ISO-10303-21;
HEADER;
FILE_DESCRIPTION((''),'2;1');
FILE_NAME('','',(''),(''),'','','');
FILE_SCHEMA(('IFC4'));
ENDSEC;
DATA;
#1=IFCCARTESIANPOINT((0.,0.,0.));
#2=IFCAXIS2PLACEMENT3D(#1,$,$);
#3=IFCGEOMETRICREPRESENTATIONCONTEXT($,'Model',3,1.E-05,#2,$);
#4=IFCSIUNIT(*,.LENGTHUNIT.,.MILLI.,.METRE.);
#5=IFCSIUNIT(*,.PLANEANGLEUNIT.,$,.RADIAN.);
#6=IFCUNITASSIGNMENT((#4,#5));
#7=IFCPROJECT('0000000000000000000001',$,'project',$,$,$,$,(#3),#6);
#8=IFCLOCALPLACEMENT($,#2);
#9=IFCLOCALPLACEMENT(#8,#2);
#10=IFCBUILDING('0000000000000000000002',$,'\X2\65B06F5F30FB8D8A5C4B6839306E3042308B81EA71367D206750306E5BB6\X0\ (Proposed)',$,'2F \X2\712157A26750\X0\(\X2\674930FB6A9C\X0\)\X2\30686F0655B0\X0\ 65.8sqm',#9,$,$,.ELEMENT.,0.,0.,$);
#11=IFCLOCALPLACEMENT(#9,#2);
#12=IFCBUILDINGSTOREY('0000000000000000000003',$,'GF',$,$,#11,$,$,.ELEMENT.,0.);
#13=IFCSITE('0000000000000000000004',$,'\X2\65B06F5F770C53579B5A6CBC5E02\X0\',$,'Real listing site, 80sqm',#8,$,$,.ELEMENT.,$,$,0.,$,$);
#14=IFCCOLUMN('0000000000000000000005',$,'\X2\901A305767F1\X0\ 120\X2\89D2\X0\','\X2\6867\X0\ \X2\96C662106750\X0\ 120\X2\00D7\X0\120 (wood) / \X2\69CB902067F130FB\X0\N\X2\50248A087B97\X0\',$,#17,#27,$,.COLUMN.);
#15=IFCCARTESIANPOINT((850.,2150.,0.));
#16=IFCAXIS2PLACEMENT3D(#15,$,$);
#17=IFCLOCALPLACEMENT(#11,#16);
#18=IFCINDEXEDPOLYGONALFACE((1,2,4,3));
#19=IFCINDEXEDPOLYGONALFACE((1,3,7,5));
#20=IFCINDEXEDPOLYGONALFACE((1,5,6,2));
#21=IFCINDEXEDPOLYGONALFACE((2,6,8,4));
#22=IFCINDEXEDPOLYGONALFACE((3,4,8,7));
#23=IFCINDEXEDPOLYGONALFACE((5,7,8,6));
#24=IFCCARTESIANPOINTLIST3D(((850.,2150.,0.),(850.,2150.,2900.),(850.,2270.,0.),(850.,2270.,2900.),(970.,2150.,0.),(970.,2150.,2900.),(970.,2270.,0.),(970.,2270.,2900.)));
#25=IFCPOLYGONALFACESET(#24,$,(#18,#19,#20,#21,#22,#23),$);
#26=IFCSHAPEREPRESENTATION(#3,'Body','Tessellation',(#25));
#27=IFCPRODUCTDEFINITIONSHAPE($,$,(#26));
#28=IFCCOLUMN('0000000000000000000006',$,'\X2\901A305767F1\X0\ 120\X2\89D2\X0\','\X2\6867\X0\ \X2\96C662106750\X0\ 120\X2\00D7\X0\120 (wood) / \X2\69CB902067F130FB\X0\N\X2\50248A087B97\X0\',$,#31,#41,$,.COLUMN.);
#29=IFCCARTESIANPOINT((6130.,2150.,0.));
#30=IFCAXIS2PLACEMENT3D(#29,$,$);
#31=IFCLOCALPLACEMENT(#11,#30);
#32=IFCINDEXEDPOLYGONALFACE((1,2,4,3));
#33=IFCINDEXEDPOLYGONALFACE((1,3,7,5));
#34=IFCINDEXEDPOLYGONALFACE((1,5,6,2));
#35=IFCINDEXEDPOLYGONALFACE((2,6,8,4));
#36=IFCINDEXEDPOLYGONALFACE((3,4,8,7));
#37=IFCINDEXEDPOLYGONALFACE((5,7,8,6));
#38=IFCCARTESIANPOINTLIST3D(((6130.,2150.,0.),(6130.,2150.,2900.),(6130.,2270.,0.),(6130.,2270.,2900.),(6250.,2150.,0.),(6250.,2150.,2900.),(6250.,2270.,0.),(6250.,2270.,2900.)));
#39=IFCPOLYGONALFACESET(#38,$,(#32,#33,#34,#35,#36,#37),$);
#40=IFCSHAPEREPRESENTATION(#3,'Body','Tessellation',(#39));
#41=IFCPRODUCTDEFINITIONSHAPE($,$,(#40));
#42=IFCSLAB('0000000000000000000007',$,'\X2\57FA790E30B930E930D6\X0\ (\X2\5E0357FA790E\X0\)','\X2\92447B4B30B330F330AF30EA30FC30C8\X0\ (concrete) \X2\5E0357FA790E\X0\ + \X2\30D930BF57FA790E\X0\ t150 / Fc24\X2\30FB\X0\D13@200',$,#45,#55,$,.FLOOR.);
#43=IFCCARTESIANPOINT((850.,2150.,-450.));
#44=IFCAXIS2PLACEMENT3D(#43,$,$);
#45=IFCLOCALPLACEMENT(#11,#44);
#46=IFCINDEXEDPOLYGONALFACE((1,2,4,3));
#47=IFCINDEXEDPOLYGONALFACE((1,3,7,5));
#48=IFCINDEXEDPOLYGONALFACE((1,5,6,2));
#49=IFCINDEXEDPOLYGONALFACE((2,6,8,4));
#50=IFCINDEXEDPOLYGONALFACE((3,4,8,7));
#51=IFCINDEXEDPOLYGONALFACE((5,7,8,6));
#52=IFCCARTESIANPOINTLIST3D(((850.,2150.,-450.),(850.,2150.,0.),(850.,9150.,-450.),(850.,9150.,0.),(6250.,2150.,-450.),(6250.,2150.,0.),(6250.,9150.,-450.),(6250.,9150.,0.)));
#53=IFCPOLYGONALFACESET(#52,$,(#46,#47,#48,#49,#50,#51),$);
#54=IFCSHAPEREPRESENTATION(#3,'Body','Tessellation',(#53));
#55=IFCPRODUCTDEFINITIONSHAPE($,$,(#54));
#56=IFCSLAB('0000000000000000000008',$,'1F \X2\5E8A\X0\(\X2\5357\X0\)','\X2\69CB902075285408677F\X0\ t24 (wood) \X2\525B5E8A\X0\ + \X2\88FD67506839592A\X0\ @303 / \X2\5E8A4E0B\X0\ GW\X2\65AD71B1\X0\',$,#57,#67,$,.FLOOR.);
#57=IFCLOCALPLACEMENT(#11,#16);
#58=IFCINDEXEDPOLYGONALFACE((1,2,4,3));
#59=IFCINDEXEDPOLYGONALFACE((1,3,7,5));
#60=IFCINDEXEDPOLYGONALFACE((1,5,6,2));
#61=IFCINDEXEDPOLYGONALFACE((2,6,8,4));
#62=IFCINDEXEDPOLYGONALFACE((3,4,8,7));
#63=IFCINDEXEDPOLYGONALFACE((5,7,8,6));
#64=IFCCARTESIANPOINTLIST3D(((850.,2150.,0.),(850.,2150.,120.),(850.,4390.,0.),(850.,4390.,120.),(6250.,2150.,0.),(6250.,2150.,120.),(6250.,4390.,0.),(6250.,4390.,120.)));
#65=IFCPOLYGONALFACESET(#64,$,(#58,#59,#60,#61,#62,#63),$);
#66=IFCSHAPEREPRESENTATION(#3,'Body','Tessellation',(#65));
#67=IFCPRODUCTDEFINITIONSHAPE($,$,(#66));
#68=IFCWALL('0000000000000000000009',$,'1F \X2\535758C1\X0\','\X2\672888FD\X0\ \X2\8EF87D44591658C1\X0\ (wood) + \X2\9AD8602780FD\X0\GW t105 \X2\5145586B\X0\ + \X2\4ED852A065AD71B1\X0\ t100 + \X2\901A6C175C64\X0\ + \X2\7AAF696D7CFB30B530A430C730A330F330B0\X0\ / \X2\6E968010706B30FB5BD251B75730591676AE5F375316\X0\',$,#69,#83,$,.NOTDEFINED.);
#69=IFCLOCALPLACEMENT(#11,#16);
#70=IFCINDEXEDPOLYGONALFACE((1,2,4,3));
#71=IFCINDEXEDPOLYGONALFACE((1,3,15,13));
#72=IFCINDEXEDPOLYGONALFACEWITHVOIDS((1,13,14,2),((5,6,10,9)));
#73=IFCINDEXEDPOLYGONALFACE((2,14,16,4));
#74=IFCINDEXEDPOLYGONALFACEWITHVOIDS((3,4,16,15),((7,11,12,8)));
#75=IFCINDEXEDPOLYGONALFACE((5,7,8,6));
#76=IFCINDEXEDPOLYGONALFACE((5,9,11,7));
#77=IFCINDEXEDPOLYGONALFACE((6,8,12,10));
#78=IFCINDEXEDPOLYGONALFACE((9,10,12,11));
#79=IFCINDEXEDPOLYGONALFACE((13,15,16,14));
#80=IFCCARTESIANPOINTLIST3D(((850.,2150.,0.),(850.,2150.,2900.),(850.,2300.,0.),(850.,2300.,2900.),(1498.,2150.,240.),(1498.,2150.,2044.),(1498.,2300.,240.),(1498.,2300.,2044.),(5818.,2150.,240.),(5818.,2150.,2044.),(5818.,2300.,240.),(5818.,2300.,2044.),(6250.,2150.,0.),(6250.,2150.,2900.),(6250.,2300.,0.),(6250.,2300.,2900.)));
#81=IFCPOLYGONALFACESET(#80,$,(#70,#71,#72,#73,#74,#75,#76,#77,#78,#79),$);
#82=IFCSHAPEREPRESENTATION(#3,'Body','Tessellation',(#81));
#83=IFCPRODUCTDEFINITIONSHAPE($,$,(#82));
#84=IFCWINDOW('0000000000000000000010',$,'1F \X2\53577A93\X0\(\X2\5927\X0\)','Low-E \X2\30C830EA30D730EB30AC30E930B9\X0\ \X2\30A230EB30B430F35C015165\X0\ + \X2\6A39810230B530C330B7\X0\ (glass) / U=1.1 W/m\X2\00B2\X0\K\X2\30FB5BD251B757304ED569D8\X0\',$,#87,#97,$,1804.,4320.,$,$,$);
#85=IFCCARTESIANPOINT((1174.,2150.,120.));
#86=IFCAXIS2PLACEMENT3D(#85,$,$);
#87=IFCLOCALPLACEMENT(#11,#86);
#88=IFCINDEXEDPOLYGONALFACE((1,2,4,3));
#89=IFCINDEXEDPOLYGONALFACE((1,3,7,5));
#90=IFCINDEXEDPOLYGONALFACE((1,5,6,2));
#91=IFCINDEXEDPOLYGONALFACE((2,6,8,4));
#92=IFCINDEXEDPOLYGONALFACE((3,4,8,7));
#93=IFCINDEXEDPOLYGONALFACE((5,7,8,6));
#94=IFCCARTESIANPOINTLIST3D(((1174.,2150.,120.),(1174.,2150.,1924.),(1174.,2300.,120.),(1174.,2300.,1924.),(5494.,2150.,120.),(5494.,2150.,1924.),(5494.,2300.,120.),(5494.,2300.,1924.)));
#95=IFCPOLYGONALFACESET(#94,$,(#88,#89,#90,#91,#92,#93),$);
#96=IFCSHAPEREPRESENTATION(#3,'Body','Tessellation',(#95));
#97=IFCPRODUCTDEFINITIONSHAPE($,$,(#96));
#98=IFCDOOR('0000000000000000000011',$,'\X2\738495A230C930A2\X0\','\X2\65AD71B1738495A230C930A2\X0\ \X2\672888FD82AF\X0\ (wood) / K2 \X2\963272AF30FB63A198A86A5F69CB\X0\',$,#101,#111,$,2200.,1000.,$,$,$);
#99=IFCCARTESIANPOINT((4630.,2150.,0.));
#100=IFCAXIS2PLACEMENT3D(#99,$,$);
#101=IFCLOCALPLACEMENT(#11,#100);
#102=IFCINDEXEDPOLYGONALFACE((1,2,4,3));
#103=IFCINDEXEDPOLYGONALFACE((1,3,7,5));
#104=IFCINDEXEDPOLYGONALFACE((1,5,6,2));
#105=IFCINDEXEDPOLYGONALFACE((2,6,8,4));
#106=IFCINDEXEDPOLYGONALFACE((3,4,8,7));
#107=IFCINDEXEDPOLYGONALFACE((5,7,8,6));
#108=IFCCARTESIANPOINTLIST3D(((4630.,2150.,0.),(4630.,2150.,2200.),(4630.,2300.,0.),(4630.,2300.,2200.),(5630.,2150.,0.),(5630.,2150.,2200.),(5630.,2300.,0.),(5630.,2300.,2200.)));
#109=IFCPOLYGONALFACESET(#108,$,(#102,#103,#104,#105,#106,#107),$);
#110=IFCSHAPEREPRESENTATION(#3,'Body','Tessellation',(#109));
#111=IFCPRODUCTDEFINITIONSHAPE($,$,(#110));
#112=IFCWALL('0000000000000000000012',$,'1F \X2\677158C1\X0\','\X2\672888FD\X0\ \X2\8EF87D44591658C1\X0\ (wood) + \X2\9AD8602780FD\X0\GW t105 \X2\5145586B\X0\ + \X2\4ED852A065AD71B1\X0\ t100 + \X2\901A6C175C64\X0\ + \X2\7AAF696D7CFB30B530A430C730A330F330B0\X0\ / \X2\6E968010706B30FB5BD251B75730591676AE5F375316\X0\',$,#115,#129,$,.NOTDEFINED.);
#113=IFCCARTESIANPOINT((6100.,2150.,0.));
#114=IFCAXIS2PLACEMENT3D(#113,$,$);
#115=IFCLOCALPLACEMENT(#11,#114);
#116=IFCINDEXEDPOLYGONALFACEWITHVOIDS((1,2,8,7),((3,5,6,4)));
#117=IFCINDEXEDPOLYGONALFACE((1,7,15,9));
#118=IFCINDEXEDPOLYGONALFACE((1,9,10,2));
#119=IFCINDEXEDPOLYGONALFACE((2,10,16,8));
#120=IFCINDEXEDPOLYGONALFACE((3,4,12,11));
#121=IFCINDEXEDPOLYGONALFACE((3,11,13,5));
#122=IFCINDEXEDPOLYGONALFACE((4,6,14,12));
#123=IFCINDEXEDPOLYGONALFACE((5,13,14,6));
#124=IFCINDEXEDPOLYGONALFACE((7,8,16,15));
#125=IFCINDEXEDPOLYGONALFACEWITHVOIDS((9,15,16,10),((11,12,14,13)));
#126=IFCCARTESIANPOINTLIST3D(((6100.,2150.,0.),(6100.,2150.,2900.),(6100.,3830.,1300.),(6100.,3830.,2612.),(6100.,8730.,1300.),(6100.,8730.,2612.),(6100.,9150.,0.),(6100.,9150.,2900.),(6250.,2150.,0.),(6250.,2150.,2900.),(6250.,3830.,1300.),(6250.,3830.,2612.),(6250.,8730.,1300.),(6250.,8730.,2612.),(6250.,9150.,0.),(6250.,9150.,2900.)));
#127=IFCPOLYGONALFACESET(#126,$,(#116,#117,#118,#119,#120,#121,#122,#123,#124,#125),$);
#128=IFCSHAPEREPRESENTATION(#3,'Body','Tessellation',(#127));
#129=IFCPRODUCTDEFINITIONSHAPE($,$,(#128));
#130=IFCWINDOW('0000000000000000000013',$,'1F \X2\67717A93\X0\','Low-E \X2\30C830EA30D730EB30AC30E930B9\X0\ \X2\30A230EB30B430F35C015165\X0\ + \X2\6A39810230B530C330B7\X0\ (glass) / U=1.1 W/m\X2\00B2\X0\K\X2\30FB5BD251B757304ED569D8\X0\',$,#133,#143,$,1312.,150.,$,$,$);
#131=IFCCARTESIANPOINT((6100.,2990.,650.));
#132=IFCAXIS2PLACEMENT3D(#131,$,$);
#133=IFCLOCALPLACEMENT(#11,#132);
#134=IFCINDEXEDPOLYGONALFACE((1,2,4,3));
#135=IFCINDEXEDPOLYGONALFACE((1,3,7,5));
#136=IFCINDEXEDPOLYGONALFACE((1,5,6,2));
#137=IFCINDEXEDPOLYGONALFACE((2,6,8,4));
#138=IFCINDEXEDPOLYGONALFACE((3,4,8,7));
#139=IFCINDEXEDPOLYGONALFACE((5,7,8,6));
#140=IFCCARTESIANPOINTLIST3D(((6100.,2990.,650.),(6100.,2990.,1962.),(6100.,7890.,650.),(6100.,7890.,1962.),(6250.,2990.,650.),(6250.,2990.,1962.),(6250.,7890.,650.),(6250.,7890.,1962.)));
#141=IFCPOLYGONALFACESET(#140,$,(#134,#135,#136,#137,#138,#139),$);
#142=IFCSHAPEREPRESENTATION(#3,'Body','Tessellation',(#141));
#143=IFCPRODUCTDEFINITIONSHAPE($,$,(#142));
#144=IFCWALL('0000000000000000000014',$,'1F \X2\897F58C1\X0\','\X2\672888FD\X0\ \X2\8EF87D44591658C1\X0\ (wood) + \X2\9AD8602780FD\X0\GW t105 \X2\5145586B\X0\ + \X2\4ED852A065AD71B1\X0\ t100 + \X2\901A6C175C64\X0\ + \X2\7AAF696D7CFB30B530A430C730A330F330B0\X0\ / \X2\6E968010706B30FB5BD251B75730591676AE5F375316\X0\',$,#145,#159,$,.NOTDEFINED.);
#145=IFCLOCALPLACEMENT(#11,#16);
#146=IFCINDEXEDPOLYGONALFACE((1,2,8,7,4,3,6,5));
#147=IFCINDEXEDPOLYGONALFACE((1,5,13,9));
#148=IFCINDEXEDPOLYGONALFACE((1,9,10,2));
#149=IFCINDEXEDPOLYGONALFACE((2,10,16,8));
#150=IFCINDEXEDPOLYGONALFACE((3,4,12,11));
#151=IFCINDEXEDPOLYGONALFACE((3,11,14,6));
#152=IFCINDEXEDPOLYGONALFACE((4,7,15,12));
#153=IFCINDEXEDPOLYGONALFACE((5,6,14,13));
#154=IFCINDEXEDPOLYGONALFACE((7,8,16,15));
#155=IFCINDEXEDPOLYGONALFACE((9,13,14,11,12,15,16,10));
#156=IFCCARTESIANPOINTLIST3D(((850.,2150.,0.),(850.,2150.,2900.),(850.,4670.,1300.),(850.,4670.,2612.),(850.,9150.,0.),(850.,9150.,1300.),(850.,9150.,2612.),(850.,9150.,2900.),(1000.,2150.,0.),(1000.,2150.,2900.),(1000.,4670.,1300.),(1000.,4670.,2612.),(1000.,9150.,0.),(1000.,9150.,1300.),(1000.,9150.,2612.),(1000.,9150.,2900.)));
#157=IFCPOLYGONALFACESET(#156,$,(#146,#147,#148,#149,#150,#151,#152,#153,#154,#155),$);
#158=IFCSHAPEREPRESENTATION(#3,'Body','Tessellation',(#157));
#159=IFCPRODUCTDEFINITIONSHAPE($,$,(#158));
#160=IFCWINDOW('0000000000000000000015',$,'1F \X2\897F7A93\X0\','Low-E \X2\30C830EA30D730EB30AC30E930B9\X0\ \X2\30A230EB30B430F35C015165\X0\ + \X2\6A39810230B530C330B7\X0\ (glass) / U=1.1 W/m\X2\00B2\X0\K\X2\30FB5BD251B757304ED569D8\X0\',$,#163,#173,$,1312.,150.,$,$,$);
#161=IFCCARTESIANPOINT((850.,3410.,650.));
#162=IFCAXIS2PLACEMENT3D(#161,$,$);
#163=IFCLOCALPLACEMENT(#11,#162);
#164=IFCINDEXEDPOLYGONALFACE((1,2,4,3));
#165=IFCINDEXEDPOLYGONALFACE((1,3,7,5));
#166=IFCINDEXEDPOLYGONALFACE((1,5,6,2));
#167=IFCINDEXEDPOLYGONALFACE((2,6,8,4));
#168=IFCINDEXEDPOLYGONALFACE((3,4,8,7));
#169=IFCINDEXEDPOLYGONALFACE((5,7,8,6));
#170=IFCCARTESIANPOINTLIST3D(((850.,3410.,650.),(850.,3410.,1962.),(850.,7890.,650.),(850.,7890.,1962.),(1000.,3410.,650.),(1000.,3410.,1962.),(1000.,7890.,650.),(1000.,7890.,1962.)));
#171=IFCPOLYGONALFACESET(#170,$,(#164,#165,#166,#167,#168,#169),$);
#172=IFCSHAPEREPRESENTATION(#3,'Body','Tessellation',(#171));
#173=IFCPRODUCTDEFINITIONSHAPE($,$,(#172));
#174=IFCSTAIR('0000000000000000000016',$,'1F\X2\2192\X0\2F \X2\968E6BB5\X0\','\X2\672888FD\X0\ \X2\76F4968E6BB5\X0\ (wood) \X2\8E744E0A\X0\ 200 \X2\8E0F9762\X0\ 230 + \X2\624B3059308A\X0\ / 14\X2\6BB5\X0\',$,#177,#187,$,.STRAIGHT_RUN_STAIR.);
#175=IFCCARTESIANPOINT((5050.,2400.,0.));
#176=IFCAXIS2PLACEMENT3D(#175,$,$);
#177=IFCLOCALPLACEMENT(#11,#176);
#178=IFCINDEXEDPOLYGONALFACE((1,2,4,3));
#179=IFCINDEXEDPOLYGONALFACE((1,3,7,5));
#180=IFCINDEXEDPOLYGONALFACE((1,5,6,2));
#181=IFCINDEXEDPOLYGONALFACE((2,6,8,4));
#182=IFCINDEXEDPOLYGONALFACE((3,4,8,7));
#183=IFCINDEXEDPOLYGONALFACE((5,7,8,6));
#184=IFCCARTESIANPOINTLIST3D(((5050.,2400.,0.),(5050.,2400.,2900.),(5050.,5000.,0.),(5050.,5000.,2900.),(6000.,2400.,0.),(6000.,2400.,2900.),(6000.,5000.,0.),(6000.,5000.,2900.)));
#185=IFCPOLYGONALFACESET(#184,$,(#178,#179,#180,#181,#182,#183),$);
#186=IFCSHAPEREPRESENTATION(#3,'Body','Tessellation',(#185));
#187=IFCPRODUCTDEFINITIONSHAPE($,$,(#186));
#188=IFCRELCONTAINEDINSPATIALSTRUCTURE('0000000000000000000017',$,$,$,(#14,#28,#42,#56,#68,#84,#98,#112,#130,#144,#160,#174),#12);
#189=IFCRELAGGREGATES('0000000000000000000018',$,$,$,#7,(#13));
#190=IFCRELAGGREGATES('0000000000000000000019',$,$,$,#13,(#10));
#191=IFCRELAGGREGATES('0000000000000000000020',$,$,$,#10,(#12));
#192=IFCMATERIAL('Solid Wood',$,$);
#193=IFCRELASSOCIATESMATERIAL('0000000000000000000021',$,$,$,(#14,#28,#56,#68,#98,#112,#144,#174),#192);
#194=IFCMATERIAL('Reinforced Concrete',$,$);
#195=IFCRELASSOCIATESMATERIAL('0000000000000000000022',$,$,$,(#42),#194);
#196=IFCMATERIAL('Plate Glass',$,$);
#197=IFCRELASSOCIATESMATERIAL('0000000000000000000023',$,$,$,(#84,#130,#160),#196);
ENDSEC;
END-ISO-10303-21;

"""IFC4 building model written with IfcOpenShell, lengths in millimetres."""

from ifc_helpers import new_model, si_unit, frame, frame_2d, origin, place, context, project, spatial, rectangle, extrude, material, element, fill, save


model = new_model("IFC4")

# Units and contexts
model_context = context("Model", 3, precision=1e-05, world=origin())
ifc_project = project(units=[si_unit("LENGTHUNIT", "METRE", prefix="MILLI"), si_unit("PLANEANGLEUNIT", "RADIAN")], contexts=[model_context])

# Site, building, storey
site_placement = place(None, origin())
site = spatial("IfcSite", under=ifc_project, at=site_placement, Name="新潟県南魚沼市", ObjectType="Real listing site, 80sqm", CompositionType="ELEMENT", RefElevation=0.0)
building_placement = place(site_placement, origin())
building = spatial("IfcBuilding", under=site, at=building_placement, Name="新潟・越屋根のある自然素材の家 (Proposed)", ObjectType="2F 無垢材(杉・檜)と漆喰 65.8sqm", CompositionType="ELEMENT", ElevationOfRefHeight=0.0, ElevationOfTerrain=0.0)
storey_placement = place(building_placement, origin())
storey = spatial("IfcBuildingStorey", under=building, at=storey_placement, Name="GF", CompositionType="ELEMENT", Elevation=0.0)

# Columns
ifc_material_1 = material(Name="Solid Wood")
column_1_placement = place(storey_placement, frame((850.0, 2150.0, 0.0)))
element("IfcColumn", 1, at=column_1_placement, inside=storey, material=ifc_material_1, Name="通し柱 120角", Description="桧 集成材 120×120 (wood) / 構造柱・N値計算", PredefinedType="COLUMN", context=model_context, shape_type="SweptSolid", body=[
    extrude(rectangle(XDim=120.0, YDim=120.0, at=frame_2d((60.0, 60.0))), frame((850.0, 2150.0, 0.0)), (0.0, 0.0, 1.0), 2900.0),
])
column_2_placement = place(storey_placement, frame((6130.0, 2150.0, 0.0)))
element("IfcColumn", 2, at=column_2_placement, inside=storey, material=ifc_material_1, Name="通し柱 120角", Description="桧 集成材 120×120 (wood) / 構造柱・N値計算", PredefinedType="COLUMN", context=model_context, shape_type="SweptSolid", body=[
    extrude(rectangle(XDim=120.0, YDim=120.0, at=frame_2d((60.0, 60.0))), frame((6130.0, 2150.0, 0.0)), (0.0, 0.0, 1.0), 2900.0),
])

# Slabs
ifc_material_2 = material(Name="Reinforced Concrete")
slab_1_placement = place(storey_placement, frame((850.0, 2150.0, -450.0)))
element("IfcSlab", 3, at=slab_1_placement, inside=storey, material=ifc_material_2, Name="基礎スラブ (布基礎)", Description="鉄筋コンクリート (concrete) 布基礎 + ベタ基礎 t150 / Fc24・D13@200", PredefinedType="FLOOR", context=model_context, shape_type="SweptSolid", body=[
    extrude(rectangle(XDim=5400.0, YDim=7000.0, at=frame_2d((2700.0, 3500.0))), frame((850.0, 2150.0, -450.0)), (0.0, 0.0, 1.0), 450.0),
])
slab_2_placement = place(storey_placement, frame((850.0, 2150.0, 0.0)))
element("IfcSlab", 4, at=slab_2_placement, inside=storey, material=ifc_material_1, Name="1F 床(南)", Description="構造用合板 t24 (wood) 剛床 + 製材根太 @303 / 床下 GW断熱", PredefinedType="FLOOR", context=model_context, shape_type="SweptSolid", body=[
    extrude(rectangle(XDim=5400.0, YDim=2240.0, at=frame_2d((2700.0, 1120.0))), frame((850.0, 2150.0, 0.0)), (0.0, 0.0, 1.0), 120.0),
])

# Wall, openings, window, door
wall_1_placement = place(storey_placement, frame((850.0, 2150.0, 0.0)))
wall_1 = element("IfcWall", 5, at=wall_1_placement, inside=storey, material=ifc_material_1, Name="1F 南壁", Description="木製 軸組外壁 (wood) + 高性能GW t105 充填 + 付加断熱 t100 + 通気層 + 窯業系サイディング / 準耐火・寒冷地外皮強化", PredefinedType="NOTDEFINED", context=model_context, shape_type="SweptSolid", body=[
    extrude(rectangle(XDim=5400.0, YDim=150.0, at=frame_2d((2700.0, 75.0))), frame((850.0, 2150.0, 0.0)), (0.0, 0.0, 1.0), 2900.0),
])
opening_1_placement = place(storey_placement, frame((1174.0, 2150.0, 120.0)))
opening_1 = element("IfcOpeningElement", 6, at=opening_1_placement, cuts=wall_1, PredefinedType="NOTDEFINED", context=model_context, shape_type="SweptSolid", body=[
    extrude(rectangle(XDim=4320.0, YDim=150.0, at=frame_2d((2160.0, 75.0))), frame((1174.0, 2150.0, 120.0)), (0.0, 0.0, 1.0), 1804.0),
])
opening_2_placement = place(storey_placement, frame((4630.0, 2150.0, 0.0)))
opening_2 = element("IfcOpeningElement", 7, at=opening_2_placement, cuts=wall_1, PredefinedType="NOTDEFINED", context=model_context, shape_type="SweptSolid", body=[
    extrude(rectangle(XDim=1000.0, YDim=150.0, at=frame_2d((500.0, 75.0))), frame((4630.0, 2150.0, 0.0)), (0.0, 0.0, 1.0), 2200.0),
])
ifc_material_3 = material(Name="Plate Glass")
window_1_placement = place(storey_placement, frame((1174.0, 2150.0, 120.0)))
window_1 = element("IfcWindow", 8, at=window_1_placement, inside=storey, material=ifc_material_3, Name="1F 南窓(大)", Description="Low-E トリプルガラス アルゴン封入 + 樹脂サッシ (glass) / U=1.1 W/m²K・寒冷地仕様", OverallHeight=1804.0, OverallWidth=4320.0, context=model_context, shape_type="SweptSolid", body=[
    extrude(rectangle(XDim=4320.0, YDim=150.0, at=frame_2d((2160.0, 75.0))), frame((1174.0, 2150.0, 120.0)), (0.0, 0.0, 1.0), 1804.0),
])
fill(opening_1, window_1)
door_placement = place(storey_placement, frame((4630.0, 2150.0, 0.0)))
door = element("IfcDoor", 9, at=door_placement, inside=storey, material=ifc_material_1, Name="玄関ドア", Description="断熱玄関ドア 木製芯 (wood) / K2 防犯・採風機構", OverallHeight=2200.0, OverallWidth=1000.0, context=model_context, shape_type="SweptSolid", body=[
    extrude(rectangle(XDim=1000.0, YDim=150.0, at=frame_2d((500.0, 75.0))), frame((4630.0, 2150.0, 0.0)), (0.0, 0.0, 1.0), 2200.0),
])
fill(opening_2, door)

# Walls, openings, windows
wall_2_placement = place(storey_placement, frame((6100.0, 2150.0, 0.0)))
wall_2 = element("IfcWall", 10, at=wall_2_placement, inside=storey, material=ifc_material_1, Name="1F 東壁", Description="木製 軸組外壁 (wood) + 高性能GW t105 充填 + 付加断熱 t100 + 通気層 + 窯業系サイディング / 準耐火・寒冷地外皮強化", PredefinedType="NOTDEFINED", context=model_context, shape_type="SweptSolid", body=[
    extrude(rectangle(XDim=150.0, YDim=7000.0, at=frame_2d((75.0, 3500.0))), frame((6100.0, 2150.0, 0.0)), (0.0, 0.0, 1.0), 2900.0),
])
opening_3_placement = place(storey_placement, frame((6100.0, 2990.0, 650.0)))
opening_3 = element("IfcOpeningElement", 11, at=opening_3_placement, cuts=wall_2, PredefinedType="NOTDEFINED", context=model_context, shape_type="SweptSolid", body=[
    extrude(rectangle(XDim=150.0, YDim=4900.0, at=frame_2d((75.0, 2450.0))), frame((6100.0, 2990.0, 650.0)), (0.0, 0.0, 1.0), 1312.0),
])
window_2_placement = place(storey_placement, frame((6100.0, 2990.0, 650.0)))
window_2 = element("IfcWindow", 12, at=window_2_placement, inside=storey, material=ifc_material_3, Name="1F 東窓", Description="Low-E トリプルガラス アルゴン封入 + 樹脂サッシ (glass) / U=1.1 W/m²K・寒冷地仕様", OverallHeight=1312.0, OverallWidth=150.0, context=model_context, shape_type="SweptSolid", body=[
    extrude(rectangle(XDim=150.0, YDim=4900.0, at=frame_2d((75.0, 2450.0))), frame((6100.0, 2990.0, 650.0)), (0.0, 0.0, 1.0), 1312.0),
])
fill(opening_3, window_2)
wall_3_placement = place(storey_placement, frame((850.0, 2150.0, 0.0)))
wall_3 = element("IfcWall", 13, at=wall_3_placement, inside=storey, material=ifc_material_1, Name="1F 西壁", Description="木製 軸組外壁 (wood) + 高性能GW t105 充填 + 付加断熱 t100 + 通気層 + 窯業系サイディング / 準耐火・寒冷地外皮強化", PredefinedType="NOTDEFINED", context=model_context, shape_type="SweptSolid", body=[
    extrude(rectangle(XDim=150.0, YDim=7000.0, at=frame_2d((75.0, 3500.0))), frame((850.0, 2150.0, 0.0)), (0.0, 0.0, 1.0), 2900.0),
])
opening_4_placement = place(storey_placement, frame((850.0, 3410.0, 650.0)))
opening_4 = element("IfcOpeningElement", 14, at=opening_4_placement, cuts=wall_3, PredefinedType="NOTDEFINED", context=model_context, shape_type="SweptSolid", body=[
    extrude(rectangle(XDim=150.0, YDim=4480.0, at=frame_2d((75.0, 2240.0))), frame((850.0, 3410.0, 650.0)), (0.0, 0.0, 1.0), 1312.0),
])
window_3_placement = place(storey_placement, frame((850.0, 3410.0, 650.0)))
window_3 = element("IfcWindow", 15, at=window_3_placement, inside=storey, material=ifc_material_3, Name="1F 西窓", Description="Low-E トリプルガラス アルゴン封入 + 樹脂サッシ (glass) / U=1.1 W/m²K・寒冷地仕様", OverallHeight=1312.0, OverallWidth=150.0, context=model_context, shape_type="SweptSolid", body=[
    extrude(rectangle(XDim=150.0, YDim=4480.0, at=frame_2d((75.0, 2240.0))), frame((850.0, 3410.0, 650.0)), (0.0, 0.0, 1.0), 1312.0),
])
fill(opening_4, window_3)

# Stair
stair_placement = place(storey_placement, frame((5050.0, 2400.0, 0.0)))
element("IfcStair", 16, at=stair_placement, inside=storey, material=ifc_material_1, Name="1F→2F 階段", Description="木製 直階段 (wood) 蹴上 200 踏面 230 + 手すり / 14段", PredefinedType="STRAIGHT_RUN_STAIR", context=model_context, shape_type="SweptSolid", body=[
    extrude(rectangle(XDim=950.0, YDim=2600.0, at=frame_2d((475.0, 1300.0))), frame((5050.0, 2400.0, 0.0)), (0.0, 0.0, 1.0), 2900.0),
])

save(model, "model.ifc")
